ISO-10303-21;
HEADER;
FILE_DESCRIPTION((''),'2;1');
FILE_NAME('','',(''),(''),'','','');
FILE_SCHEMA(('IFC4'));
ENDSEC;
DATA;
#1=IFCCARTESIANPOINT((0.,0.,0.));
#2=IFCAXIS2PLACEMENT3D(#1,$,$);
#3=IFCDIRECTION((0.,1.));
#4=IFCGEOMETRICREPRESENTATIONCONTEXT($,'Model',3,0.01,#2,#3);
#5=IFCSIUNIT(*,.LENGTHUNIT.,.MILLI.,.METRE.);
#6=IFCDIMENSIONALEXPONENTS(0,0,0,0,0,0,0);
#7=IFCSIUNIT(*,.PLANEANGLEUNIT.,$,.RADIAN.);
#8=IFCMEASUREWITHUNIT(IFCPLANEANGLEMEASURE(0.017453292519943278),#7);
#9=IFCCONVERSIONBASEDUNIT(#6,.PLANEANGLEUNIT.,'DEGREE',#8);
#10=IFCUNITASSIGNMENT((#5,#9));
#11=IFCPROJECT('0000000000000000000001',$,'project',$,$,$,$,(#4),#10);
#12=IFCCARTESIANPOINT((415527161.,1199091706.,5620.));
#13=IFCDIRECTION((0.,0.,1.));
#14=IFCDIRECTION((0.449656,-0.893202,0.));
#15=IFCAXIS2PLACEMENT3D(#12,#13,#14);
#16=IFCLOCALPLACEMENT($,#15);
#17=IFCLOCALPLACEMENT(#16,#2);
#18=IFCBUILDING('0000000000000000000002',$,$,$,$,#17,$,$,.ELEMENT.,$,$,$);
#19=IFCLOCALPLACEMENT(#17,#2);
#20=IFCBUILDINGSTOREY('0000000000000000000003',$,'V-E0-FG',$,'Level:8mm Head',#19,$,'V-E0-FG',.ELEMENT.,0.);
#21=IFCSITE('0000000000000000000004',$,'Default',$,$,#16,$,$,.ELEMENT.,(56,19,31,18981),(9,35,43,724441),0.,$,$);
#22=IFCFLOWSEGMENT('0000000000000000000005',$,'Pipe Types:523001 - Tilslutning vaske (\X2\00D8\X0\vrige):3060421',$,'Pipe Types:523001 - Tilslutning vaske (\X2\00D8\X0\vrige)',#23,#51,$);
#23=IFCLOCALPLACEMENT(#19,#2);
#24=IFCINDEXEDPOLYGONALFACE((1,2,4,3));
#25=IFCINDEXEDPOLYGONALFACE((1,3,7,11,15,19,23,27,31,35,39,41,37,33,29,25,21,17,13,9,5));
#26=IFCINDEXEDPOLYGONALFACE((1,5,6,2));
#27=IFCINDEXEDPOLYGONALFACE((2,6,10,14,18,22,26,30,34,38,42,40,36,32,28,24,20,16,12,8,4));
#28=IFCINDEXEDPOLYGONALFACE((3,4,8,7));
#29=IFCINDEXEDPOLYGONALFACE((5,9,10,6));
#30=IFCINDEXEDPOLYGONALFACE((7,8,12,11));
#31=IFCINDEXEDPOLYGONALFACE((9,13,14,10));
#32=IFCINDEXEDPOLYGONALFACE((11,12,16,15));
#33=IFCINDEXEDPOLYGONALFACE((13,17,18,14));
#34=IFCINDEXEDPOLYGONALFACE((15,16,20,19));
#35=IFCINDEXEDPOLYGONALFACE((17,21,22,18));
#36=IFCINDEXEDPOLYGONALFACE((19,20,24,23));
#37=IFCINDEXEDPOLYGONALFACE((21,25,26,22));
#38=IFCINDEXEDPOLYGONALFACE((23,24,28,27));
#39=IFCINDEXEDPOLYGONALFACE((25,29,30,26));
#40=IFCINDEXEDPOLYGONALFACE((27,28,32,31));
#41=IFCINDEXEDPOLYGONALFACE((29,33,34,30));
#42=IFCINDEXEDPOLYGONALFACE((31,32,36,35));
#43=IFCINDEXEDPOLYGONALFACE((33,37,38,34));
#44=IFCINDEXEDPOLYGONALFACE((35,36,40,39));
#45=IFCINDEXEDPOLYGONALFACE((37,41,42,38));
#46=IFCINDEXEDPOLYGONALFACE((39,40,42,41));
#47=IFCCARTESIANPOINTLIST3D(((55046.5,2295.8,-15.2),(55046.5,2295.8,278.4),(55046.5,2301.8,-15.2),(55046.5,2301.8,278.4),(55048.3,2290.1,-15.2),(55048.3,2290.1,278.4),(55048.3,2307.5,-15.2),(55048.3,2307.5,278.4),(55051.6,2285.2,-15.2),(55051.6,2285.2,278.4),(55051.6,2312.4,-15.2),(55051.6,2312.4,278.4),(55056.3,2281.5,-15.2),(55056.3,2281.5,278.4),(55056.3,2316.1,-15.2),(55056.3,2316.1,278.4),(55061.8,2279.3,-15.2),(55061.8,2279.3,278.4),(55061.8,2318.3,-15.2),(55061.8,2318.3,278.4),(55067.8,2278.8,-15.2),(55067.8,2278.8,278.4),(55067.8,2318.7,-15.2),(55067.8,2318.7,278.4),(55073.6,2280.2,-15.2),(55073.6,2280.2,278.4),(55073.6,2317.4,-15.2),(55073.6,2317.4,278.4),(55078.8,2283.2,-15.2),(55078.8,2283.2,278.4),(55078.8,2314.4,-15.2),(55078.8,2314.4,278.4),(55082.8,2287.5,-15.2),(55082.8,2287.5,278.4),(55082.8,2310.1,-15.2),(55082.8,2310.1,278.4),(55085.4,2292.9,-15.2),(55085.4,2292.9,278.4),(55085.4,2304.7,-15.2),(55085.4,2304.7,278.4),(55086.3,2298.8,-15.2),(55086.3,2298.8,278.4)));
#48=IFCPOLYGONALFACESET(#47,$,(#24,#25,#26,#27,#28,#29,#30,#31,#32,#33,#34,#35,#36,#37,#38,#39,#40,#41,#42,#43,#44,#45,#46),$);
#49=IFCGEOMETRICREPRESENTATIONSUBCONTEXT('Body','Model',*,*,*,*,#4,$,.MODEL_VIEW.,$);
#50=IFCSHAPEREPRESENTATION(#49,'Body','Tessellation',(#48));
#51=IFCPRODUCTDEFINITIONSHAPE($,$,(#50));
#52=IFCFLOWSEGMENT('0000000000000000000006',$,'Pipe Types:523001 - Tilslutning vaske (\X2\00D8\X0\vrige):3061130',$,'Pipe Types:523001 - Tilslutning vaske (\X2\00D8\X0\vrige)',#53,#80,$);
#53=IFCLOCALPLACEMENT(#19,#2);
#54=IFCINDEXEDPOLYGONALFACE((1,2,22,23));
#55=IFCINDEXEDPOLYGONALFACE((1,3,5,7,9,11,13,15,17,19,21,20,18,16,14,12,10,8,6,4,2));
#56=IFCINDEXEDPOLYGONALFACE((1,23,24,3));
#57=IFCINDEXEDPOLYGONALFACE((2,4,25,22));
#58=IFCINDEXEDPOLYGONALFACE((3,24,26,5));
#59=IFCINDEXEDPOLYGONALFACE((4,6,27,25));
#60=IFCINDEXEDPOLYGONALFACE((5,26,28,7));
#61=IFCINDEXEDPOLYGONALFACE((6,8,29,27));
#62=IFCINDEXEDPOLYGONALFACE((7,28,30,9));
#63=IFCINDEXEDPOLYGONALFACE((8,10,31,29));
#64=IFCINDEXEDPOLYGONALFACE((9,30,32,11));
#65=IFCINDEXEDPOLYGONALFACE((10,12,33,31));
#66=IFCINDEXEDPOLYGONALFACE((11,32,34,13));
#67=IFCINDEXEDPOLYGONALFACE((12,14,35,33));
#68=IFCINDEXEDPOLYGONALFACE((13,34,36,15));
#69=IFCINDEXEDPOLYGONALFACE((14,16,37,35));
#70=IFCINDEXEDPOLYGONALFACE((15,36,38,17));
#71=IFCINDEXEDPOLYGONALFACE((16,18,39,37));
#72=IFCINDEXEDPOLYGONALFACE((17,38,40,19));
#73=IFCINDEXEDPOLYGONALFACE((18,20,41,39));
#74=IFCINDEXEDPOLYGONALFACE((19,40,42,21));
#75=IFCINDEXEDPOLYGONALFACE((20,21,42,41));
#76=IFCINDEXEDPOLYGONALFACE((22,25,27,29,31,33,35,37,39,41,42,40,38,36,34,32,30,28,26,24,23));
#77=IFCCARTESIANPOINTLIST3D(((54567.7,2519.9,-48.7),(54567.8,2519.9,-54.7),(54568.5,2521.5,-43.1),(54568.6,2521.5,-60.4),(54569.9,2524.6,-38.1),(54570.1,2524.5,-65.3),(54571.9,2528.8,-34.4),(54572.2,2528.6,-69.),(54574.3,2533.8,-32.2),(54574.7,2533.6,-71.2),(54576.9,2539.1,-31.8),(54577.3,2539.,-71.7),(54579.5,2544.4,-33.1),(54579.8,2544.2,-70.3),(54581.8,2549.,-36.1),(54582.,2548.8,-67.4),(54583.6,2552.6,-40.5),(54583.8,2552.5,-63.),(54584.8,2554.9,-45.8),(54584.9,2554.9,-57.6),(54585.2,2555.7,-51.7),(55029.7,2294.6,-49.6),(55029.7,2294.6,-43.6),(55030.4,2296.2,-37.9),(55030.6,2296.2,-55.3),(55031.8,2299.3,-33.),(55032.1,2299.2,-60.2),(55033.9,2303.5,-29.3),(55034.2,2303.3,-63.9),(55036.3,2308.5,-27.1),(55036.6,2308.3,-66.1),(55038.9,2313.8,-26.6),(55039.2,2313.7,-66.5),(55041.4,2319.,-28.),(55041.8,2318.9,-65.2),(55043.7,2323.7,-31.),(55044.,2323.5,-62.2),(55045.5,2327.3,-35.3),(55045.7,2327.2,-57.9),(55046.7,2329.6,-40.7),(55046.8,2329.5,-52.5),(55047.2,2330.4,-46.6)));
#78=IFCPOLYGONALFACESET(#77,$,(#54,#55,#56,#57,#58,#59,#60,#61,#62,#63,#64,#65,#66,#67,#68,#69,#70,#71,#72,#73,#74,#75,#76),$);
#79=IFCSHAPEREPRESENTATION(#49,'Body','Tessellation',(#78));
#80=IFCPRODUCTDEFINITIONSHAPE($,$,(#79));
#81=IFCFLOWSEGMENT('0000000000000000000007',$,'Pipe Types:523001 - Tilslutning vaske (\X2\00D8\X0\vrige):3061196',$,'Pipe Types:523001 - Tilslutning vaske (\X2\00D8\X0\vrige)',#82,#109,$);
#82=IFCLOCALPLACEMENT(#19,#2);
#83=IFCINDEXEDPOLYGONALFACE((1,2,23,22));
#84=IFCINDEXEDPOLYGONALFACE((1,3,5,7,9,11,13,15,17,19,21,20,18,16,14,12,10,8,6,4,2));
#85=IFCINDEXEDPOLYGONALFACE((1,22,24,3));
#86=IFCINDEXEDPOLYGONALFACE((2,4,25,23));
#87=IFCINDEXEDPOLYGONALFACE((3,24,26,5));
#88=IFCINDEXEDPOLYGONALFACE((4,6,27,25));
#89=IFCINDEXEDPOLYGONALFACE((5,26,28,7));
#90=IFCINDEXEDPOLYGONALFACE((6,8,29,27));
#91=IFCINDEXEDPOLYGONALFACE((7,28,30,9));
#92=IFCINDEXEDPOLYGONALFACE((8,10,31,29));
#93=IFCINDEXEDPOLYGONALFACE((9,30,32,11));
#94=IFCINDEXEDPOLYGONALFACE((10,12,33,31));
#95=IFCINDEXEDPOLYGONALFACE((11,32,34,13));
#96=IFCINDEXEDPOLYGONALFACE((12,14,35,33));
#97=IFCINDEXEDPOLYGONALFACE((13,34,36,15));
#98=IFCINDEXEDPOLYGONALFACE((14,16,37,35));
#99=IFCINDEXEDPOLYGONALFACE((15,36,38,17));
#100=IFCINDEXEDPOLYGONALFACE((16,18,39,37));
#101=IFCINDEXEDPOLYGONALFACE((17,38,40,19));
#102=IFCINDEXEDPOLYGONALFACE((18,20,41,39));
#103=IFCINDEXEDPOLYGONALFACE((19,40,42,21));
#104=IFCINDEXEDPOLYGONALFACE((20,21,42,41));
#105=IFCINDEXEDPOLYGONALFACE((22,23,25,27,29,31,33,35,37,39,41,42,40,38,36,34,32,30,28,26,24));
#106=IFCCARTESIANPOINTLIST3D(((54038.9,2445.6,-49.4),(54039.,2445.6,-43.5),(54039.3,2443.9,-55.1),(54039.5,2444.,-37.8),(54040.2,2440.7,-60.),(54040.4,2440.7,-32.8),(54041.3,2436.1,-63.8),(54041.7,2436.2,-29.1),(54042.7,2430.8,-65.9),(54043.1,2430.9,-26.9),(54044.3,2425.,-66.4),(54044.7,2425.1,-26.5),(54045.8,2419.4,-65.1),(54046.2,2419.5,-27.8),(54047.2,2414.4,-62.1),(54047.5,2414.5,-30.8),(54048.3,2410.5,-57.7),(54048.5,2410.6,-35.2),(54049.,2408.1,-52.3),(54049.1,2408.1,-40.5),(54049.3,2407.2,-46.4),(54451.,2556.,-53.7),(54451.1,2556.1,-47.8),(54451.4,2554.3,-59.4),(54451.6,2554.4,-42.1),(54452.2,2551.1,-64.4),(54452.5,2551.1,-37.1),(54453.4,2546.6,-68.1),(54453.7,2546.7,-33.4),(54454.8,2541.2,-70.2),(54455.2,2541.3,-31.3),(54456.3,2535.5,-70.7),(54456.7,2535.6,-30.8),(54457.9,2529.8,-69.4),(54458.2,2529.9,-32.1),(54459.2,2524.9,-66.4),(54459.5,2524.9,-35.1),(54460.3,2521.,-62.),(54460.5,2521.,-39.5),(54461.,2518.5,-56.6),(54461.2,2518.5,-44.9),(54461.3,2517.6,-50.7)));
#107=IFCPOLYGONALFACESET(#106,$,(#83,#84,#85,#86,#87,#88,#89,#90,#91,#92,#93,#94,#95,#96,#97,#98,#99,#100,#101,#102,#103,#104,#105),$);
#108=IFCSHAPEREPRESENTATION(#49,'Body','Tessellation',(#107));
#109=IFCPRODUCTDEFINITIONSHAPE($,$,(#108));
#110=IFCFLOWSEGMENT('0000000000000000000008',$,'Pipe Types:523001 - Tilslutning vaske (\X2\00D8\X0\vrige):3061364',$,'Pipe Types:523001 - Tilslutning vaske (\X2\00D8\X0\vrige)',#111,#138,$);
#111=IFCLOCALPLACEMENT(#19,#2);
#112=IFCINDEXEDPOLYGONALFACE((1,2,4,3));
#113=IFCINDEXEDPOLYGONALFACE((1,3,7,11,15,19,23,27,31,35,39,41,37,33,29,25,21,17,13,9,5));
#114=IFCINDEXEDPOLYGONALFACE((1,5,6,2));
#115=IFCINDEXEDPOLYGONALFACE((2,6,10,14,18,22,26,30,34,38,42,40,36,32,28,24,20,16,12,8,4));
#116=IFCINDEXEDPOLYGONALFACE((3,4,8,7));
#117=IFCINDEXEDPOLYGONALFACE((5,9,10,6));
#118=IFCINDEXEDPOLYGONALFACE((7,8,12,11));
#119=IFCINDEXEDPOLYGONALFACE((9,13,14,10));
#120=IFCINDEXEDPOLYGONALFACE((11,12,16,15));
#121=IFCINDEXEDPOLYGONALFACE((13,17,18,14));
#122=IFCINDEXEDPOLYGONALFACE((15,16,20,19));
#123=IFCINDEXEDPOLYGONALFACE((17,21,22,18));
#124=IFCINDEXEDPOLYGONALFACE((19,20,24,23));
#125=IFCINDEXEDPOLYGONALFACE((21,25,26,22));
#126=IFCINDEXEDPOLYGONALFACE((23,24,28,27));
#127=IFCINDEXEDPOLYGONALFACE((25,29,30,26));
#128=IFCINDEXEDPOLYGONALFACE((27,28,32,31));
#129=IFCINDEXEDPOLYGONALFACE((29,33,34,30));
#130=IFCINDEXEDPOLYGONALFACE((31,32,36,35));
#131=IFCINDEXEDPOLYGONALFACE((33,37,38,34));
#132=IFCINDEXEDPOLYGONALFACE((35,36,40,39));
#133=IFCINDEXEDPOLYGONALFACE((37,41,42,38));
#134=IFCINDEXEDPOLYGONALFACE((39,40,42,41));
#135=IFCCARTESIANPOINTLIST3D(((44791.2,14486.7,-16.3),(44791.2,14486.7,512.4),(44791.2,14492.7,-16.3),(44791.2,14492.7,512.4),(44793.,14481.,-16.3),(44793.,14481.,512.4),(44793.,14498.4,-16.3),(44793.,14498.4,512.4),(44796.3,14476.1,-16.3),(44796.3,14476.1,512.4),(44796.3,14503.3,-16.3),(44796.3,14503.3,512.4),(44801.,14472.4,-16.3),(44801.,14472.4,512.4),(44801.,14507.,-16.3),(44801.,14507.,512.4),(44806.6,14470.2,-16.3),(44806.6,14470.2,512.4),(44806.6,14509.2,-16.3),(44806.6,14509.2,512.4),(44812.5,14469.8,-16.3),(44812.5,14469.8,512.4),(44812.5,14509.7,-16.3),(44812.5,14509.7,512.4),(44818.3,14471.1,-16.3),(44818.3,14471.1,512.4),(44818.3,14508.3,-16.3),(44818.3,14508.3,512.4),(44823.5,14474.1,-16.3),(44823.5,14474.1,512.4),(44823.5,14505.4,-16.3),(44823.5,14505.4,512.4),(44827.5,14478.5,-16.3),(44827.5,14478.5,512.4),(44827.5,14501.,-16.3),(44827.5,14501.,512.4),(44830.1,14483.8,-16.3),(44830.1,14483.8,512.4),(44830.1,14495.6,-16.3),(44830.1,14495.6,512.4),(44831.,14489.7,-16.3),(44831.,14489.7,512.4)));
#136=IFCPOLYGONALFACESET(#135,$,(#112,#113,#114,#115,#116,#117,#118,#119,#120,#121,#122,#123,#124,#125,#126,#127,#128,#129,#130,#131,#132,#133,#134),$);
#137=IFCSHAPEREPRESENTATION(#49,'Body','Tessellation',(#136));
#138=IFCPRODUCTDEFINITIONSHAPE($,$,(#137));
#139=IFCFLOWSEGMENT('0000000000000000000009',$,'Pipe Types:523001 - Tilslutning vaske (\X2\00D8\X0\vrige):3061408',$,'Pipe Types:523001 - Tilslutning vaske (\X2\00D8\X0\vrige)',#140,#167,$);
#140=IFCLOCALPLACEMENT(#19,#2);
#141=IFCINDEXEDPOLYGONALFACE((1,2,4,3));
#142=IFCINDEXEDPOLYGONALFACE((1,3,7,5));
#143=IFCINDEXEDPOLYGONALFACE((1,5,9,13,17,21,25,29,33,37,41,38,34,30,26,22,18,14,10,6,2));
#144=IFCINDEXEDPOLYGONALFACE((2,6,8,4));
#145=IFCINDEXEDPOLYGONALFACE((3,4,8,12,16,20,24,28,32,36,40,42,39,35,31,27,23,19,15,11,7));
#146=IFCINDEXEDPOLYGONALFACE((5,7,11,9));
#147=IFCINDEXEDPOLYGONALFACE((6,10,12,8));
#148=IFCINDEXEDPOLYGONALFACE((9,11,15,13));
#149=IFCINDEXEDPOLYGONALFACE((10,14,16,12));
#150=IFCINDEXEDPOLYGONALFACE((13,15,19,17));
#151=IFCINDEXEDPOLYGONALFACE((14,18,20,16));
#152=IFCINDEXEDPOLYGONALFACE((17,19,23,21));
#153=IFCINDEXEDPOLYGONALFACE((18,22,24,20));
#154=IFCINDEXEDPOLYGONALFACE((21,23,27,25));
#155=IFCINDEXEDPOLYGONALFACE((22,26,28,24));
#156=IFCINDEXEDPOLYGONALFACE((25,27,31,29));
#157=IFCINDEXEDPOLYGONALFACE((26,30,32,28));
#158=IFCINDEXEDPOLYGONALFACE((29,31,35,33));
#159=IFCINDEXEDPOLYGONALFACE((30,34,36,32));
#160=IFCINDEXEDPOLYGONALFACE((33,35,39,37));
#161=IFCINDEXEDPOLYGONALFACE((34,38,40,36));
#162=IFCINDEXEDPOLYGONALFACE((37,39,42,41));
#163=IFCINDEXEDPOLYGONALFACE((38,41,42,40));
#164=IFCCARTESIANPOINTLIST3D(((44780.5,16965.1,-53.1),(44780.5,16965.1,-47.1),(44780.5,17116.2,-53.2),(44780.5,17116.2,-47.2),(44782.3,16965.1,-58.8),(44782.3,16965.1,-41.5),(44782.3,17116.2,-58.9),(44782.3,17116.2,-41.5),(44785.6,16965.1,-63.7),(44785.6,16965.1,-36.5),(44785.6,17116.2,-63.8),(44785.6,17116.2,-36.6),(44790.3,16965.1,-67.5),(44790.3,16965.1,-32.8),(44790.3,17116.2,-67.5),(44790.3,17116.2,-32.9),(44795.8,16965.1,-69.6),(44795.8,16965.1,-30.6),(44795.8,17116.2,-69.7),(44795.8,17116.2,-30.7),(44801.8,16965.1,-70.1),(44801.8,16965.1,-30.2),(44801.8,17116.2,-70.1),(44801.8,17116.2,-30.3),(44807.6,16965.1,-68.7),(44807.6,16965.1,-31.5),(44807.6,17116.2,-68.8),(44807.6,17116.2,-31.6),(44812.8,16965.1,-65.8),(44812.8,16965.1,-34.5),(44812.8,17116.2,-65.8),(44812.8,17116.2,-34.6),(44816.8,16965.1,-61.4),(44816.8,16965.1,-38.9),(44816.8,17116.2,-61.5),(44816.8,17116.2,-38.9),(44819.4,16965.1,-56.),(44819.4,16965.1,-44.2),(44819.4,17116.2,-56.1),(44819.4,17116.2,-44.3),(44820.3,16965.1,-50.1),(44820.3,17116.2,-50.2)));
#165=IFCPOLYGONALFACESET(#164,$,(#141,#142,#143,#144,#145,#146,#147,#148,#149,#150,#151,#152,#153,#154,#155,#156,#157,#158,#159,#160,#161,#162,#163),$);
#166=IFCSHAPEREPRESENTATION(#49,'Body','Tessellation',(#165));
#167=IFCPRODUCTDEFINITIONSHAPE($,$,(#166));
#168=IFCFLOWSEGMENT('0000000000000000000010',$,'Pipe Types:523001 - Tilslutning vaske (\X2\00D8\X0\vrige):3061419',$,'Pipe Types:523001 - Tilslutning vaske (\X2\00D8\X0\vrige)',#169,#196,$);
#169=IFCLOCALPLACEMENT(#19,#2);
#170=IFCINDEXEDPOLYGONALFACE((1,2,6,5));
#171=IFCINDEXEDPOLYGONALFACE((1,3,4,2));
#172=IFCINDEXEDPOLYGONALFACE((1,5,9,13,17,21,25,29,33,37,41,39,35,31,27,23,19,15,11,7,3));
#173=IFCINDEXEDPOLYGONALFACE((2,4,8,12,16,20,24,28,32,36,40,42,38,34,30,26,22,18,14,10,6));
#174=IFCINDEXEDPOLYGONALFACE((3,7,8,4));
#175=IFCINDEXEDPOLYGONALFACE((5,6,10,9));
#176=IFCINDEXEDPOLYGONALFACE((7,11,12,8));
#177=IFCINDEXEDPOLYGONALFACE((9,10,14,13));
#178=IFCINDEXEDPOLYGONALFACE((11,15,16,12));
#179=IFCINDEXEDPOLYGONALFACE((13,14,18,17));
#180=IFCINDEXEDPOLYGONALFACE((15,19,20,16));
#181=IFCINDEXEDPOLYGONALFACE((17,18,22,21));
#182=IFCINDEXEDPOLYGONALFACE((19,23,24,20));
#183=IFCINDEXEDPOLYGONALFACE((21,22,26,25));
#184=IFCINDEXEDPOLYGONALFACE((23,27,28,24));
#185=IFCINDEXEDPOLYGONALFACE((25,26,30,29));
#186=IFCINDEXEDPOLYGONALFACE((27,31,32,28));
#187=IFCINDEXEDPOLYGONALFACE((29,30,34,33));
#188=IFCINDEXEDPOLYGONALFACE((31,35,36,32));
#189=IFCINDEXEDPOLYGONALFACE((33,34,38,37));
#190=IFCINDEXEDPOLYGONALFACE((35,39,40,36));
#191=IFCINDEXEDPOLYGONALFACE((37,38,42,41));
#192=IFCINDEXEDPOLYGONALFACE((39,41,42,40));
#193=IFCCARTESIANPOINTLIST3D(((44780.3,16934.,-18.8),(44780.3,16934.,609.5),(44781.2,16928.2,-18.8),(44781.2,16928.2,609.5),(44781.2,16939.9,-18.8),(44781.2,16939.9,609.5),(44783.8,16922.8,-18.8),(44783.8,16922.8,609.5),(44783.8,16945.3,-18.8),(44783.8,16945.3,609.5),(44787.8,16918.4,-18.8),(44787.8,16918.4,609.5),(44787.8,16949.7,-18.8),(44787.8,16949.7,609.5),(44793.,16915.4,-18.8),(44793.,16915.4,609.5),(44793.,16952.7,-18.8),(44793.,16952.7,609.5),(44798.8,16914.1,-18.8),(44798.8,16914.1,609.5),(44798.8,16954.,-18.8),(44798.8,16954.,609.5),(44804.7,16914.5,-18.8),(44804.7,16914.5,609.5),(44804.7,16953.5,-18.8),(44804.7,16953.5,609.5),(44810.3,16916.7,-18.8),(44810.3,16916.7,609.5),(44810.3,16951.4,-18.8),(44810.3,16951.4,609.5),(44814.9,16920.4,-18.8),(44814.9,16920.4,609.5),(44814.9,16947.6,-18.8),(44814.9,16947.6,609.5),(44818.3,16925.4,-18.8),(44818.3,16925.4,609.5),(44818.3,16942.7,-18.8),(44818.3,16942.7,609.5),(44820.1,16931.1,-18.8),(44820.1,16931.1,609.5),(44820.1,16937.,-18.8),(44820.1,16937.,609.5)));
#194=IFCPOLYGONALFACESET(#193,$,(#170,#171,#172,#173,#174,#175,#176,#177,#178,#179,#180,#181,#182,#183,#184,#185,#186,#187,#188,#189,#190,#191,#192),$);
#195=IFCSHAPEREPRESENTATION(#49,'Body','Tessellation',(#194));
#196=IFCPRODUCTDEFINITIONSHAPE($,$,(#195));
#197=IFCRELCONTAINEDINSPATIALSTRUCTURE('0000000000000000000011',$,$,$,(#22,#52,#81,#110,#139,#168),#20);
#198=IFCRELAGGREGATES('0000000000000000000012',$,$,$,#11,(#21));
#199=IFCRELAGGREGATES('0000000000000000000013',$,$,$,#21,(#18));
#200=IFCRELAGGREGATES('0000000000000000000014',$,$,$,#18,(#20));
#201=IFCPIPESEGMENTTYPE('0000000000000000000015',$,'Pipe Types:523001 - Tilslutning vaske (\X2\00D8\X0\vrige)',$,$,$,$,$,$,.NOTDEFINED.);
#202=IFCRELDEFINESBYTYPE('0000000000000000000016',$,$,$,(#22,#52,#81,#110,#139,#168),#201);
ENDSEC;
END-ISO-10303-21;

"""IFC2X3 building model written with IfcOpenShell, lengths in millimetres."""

from ifc_helpers import new_model, entity, si_unit, converted_unit, direction, frame, frame_2d, origin, origin_2d_with_axis, place, context, subcontext, project, spatial, circle, extrude, type_object, element, save


model = new_model("IFC2X3")

# Units and contexts
model_context = context("Model", 3, precision=0.01, world=origin(), true_north=direction((0.0, 1.0)))
body_context = subcontext(model_context, "Body", "Model", "MODEL_VIEW")
ifc_project = project(units=[si_unit("LENGTHUNIT", "METRE", prefix="MILLI"), converted_unit("PLANEANGLEUNIT", "DEGREE", entity("IfcPlaneAngleMeasure", 0.017453292519943278), si_unit("PLANEANGLEUNIT", "RADIAN"), dimensions=[0, 0, 0, 0, 0, 0, 0])], contexts=[model_context])

# Site, building, storey
site_placement = place(None, frame((415527161.0, 1199091706.0, 5620.0), z_axis=(0.0, 0.0, 1.0), x_axis=(0.449656, -0.893202, 0.0)))
site = spatial("IfcSite", under=ifc_project, at=site_placement, Name="Default", CompositionType="ELEMENT", RefLatitude=(56, 19, 31, 18981), RefLongitude=(9, 35, 43, 724441), RefElevation=0.0)
building_placement = place(site_placement, origin())
building = spatial("IfcBuilding", under=site, at=building_placement, CompositionType="ELEMENT")
storey_placement = place(building_placement, origin())
storey = spatial("IfcBuildingStorey", under=building, at=storey_placement, Name="V-E0-FG", ObjectType="Level:8mm Head", LongName="V-E0-FG", CompositionType="ELEMENT", Elevation=0.0)

# Flow segments
pipe_segment_type_1 = type_object("IfcPipeSegmentType", Name="Pipe Types:523001 - Tilslutning vaske (Øvrige)", PredefinedType="NOTDEFINED")
flow_segment_1_placement = place(storey_placement, origin())
element("IfcFlowSegment", 1, at=flow_segment_1_placement, inside=storey, type_object=pipe_segment_type_1, Name="Pipe Types:523001 - Tilslutning vaske (Øvrige):3060421", ObjectType="Pipe Types:523001 - Tilslutning vaske (Øvrige)", context=body_context, shape_type="SweptSolid", body=[
    extrude(circle(Radius=20.0, at=frame_2d((0.0, 0.0), x_axis=(1.0, 0.0))), frame((55066.3, 2298.8, -15.2)), (0.0, 0.0, 1.0), 293.7),
])
flow_segment_2_placement = place(storey_placement, origin())
element("IfcFlowSegment", 2, at=flow_segment_2_placement, inside=storey, type_object=pipe_segment_type_1, Name="Pipe Types:523001 - Tilslutning vaske (Øvrige):3061130", ObjectType="Pipe Types:523001 - Tilslutning vaske (Øvrige)", context=body_context, shape_type="SweptSolid", body=[
    extrude(circle(Radius=20.0, at=frame_2d((0.0, 0.0), x_axis=(1.0, 0.0))), frame((54576.4, 2537.7, -51.7), z_axis=(0.898749, -0.438349, 0.01), x_axis=(0.438371, 0.898794, 0.0)), (0.0, 0.0, 1.0), 514.0),
])
flow_segment_3_placement = place(storey_placement, origin())
element("IfcFlowSegment", 3, at=flow_segment_3_placement, inside=storey, type_object=pipe_segment_type_1, Name="Pipe Types:523001 - Tilslutning vaske (Øvrige):3061196", ObjectType="Pipe Types:523001 - Tilslutning vaske (Øvrige)", context=body_context, shape_type="SweptSolid", body=[
    extrude(circle(Radius=20.0, at=frame_2d((0.0, 0.0), x_axis=(1.0, 0.0))), frame((54044.1, 2426.5, -46.4), z_axis=(0.965877, 0.258806, -0.010093), x_axis=(0.258819, -0.965926, 0.0)), (0.0, 0.0, 1.0), 426.6),
])
flow_segment_4_placement = place(storey_placement, origin())
element("IfcFlowSegment", 4, at=flow_segment_4_placement, inside=storey, type_object=pipe_segment_type_1, Name="Pipe Types:523001 - Tilslutning vaske (Øvrige):3061364", ObjectType="Pipe Types:523001 - Tilslutning vaske (Øvrige)", context=body_context, shape_type="SweptSolid", body=[
    extrude(circle(Radius=20.0, at=origin_2d_with_axis()), frame((44811.0, 14489.7, -16.3)), (0.0, 0.0, 1.0), 528.8),
])
flow_segment_5_placement = place(storey_placement, origin())
element("IfcFlowSegment", 5, at=flow_segment_5_placement, inside=storey, type_object=pipe_segment_type_1, Name="Pipe Types:523001 - Tilslutning vaske (Øvrige):3061408", ObjectType="Pipe Types:523001 - Tilslutning vaske (Øvrige)", context=body_context, shape_type="SweptSolid", body=[
    extrude(circle(Radius=20.0, at=frame_2d((0.0, 0.0), x_axis=(1.0, 0.0))), frame((44800.3, 17116.2, -50.2), z_axis=(0.0, -1.0, 0.000428), x_axis=(1.0, 0.0, 0.0)), (0.0, 0.0, 1.0), 151.1),
])
flow_segment_6_placement = place(storey_placement, origin())
element("IfcFlowSegment", 6, at=flow_segment_6_placement, inside=storey, type_object=pipe_segment_type_1, Name="Pipe Types:523001 - Tilslutning vaske (Øvrige):3061419", ObjectType="Pipe Types:523001 - Tilslutning vaske (Øvrige)", context=body_context, shape_type="SweptSolid", body=[
    extrude(circle(Radius=20.0, at=origin_2d_with_axis()), frame((44800.3, 16934.0, -18.8), z_axis=(0.0, 0.0, 1.0), x_axis=(-1.0, 0.0, 0.0)), (0.0, 0.0, 1.0), 628.3),
])

save(model, "model.ifc")
